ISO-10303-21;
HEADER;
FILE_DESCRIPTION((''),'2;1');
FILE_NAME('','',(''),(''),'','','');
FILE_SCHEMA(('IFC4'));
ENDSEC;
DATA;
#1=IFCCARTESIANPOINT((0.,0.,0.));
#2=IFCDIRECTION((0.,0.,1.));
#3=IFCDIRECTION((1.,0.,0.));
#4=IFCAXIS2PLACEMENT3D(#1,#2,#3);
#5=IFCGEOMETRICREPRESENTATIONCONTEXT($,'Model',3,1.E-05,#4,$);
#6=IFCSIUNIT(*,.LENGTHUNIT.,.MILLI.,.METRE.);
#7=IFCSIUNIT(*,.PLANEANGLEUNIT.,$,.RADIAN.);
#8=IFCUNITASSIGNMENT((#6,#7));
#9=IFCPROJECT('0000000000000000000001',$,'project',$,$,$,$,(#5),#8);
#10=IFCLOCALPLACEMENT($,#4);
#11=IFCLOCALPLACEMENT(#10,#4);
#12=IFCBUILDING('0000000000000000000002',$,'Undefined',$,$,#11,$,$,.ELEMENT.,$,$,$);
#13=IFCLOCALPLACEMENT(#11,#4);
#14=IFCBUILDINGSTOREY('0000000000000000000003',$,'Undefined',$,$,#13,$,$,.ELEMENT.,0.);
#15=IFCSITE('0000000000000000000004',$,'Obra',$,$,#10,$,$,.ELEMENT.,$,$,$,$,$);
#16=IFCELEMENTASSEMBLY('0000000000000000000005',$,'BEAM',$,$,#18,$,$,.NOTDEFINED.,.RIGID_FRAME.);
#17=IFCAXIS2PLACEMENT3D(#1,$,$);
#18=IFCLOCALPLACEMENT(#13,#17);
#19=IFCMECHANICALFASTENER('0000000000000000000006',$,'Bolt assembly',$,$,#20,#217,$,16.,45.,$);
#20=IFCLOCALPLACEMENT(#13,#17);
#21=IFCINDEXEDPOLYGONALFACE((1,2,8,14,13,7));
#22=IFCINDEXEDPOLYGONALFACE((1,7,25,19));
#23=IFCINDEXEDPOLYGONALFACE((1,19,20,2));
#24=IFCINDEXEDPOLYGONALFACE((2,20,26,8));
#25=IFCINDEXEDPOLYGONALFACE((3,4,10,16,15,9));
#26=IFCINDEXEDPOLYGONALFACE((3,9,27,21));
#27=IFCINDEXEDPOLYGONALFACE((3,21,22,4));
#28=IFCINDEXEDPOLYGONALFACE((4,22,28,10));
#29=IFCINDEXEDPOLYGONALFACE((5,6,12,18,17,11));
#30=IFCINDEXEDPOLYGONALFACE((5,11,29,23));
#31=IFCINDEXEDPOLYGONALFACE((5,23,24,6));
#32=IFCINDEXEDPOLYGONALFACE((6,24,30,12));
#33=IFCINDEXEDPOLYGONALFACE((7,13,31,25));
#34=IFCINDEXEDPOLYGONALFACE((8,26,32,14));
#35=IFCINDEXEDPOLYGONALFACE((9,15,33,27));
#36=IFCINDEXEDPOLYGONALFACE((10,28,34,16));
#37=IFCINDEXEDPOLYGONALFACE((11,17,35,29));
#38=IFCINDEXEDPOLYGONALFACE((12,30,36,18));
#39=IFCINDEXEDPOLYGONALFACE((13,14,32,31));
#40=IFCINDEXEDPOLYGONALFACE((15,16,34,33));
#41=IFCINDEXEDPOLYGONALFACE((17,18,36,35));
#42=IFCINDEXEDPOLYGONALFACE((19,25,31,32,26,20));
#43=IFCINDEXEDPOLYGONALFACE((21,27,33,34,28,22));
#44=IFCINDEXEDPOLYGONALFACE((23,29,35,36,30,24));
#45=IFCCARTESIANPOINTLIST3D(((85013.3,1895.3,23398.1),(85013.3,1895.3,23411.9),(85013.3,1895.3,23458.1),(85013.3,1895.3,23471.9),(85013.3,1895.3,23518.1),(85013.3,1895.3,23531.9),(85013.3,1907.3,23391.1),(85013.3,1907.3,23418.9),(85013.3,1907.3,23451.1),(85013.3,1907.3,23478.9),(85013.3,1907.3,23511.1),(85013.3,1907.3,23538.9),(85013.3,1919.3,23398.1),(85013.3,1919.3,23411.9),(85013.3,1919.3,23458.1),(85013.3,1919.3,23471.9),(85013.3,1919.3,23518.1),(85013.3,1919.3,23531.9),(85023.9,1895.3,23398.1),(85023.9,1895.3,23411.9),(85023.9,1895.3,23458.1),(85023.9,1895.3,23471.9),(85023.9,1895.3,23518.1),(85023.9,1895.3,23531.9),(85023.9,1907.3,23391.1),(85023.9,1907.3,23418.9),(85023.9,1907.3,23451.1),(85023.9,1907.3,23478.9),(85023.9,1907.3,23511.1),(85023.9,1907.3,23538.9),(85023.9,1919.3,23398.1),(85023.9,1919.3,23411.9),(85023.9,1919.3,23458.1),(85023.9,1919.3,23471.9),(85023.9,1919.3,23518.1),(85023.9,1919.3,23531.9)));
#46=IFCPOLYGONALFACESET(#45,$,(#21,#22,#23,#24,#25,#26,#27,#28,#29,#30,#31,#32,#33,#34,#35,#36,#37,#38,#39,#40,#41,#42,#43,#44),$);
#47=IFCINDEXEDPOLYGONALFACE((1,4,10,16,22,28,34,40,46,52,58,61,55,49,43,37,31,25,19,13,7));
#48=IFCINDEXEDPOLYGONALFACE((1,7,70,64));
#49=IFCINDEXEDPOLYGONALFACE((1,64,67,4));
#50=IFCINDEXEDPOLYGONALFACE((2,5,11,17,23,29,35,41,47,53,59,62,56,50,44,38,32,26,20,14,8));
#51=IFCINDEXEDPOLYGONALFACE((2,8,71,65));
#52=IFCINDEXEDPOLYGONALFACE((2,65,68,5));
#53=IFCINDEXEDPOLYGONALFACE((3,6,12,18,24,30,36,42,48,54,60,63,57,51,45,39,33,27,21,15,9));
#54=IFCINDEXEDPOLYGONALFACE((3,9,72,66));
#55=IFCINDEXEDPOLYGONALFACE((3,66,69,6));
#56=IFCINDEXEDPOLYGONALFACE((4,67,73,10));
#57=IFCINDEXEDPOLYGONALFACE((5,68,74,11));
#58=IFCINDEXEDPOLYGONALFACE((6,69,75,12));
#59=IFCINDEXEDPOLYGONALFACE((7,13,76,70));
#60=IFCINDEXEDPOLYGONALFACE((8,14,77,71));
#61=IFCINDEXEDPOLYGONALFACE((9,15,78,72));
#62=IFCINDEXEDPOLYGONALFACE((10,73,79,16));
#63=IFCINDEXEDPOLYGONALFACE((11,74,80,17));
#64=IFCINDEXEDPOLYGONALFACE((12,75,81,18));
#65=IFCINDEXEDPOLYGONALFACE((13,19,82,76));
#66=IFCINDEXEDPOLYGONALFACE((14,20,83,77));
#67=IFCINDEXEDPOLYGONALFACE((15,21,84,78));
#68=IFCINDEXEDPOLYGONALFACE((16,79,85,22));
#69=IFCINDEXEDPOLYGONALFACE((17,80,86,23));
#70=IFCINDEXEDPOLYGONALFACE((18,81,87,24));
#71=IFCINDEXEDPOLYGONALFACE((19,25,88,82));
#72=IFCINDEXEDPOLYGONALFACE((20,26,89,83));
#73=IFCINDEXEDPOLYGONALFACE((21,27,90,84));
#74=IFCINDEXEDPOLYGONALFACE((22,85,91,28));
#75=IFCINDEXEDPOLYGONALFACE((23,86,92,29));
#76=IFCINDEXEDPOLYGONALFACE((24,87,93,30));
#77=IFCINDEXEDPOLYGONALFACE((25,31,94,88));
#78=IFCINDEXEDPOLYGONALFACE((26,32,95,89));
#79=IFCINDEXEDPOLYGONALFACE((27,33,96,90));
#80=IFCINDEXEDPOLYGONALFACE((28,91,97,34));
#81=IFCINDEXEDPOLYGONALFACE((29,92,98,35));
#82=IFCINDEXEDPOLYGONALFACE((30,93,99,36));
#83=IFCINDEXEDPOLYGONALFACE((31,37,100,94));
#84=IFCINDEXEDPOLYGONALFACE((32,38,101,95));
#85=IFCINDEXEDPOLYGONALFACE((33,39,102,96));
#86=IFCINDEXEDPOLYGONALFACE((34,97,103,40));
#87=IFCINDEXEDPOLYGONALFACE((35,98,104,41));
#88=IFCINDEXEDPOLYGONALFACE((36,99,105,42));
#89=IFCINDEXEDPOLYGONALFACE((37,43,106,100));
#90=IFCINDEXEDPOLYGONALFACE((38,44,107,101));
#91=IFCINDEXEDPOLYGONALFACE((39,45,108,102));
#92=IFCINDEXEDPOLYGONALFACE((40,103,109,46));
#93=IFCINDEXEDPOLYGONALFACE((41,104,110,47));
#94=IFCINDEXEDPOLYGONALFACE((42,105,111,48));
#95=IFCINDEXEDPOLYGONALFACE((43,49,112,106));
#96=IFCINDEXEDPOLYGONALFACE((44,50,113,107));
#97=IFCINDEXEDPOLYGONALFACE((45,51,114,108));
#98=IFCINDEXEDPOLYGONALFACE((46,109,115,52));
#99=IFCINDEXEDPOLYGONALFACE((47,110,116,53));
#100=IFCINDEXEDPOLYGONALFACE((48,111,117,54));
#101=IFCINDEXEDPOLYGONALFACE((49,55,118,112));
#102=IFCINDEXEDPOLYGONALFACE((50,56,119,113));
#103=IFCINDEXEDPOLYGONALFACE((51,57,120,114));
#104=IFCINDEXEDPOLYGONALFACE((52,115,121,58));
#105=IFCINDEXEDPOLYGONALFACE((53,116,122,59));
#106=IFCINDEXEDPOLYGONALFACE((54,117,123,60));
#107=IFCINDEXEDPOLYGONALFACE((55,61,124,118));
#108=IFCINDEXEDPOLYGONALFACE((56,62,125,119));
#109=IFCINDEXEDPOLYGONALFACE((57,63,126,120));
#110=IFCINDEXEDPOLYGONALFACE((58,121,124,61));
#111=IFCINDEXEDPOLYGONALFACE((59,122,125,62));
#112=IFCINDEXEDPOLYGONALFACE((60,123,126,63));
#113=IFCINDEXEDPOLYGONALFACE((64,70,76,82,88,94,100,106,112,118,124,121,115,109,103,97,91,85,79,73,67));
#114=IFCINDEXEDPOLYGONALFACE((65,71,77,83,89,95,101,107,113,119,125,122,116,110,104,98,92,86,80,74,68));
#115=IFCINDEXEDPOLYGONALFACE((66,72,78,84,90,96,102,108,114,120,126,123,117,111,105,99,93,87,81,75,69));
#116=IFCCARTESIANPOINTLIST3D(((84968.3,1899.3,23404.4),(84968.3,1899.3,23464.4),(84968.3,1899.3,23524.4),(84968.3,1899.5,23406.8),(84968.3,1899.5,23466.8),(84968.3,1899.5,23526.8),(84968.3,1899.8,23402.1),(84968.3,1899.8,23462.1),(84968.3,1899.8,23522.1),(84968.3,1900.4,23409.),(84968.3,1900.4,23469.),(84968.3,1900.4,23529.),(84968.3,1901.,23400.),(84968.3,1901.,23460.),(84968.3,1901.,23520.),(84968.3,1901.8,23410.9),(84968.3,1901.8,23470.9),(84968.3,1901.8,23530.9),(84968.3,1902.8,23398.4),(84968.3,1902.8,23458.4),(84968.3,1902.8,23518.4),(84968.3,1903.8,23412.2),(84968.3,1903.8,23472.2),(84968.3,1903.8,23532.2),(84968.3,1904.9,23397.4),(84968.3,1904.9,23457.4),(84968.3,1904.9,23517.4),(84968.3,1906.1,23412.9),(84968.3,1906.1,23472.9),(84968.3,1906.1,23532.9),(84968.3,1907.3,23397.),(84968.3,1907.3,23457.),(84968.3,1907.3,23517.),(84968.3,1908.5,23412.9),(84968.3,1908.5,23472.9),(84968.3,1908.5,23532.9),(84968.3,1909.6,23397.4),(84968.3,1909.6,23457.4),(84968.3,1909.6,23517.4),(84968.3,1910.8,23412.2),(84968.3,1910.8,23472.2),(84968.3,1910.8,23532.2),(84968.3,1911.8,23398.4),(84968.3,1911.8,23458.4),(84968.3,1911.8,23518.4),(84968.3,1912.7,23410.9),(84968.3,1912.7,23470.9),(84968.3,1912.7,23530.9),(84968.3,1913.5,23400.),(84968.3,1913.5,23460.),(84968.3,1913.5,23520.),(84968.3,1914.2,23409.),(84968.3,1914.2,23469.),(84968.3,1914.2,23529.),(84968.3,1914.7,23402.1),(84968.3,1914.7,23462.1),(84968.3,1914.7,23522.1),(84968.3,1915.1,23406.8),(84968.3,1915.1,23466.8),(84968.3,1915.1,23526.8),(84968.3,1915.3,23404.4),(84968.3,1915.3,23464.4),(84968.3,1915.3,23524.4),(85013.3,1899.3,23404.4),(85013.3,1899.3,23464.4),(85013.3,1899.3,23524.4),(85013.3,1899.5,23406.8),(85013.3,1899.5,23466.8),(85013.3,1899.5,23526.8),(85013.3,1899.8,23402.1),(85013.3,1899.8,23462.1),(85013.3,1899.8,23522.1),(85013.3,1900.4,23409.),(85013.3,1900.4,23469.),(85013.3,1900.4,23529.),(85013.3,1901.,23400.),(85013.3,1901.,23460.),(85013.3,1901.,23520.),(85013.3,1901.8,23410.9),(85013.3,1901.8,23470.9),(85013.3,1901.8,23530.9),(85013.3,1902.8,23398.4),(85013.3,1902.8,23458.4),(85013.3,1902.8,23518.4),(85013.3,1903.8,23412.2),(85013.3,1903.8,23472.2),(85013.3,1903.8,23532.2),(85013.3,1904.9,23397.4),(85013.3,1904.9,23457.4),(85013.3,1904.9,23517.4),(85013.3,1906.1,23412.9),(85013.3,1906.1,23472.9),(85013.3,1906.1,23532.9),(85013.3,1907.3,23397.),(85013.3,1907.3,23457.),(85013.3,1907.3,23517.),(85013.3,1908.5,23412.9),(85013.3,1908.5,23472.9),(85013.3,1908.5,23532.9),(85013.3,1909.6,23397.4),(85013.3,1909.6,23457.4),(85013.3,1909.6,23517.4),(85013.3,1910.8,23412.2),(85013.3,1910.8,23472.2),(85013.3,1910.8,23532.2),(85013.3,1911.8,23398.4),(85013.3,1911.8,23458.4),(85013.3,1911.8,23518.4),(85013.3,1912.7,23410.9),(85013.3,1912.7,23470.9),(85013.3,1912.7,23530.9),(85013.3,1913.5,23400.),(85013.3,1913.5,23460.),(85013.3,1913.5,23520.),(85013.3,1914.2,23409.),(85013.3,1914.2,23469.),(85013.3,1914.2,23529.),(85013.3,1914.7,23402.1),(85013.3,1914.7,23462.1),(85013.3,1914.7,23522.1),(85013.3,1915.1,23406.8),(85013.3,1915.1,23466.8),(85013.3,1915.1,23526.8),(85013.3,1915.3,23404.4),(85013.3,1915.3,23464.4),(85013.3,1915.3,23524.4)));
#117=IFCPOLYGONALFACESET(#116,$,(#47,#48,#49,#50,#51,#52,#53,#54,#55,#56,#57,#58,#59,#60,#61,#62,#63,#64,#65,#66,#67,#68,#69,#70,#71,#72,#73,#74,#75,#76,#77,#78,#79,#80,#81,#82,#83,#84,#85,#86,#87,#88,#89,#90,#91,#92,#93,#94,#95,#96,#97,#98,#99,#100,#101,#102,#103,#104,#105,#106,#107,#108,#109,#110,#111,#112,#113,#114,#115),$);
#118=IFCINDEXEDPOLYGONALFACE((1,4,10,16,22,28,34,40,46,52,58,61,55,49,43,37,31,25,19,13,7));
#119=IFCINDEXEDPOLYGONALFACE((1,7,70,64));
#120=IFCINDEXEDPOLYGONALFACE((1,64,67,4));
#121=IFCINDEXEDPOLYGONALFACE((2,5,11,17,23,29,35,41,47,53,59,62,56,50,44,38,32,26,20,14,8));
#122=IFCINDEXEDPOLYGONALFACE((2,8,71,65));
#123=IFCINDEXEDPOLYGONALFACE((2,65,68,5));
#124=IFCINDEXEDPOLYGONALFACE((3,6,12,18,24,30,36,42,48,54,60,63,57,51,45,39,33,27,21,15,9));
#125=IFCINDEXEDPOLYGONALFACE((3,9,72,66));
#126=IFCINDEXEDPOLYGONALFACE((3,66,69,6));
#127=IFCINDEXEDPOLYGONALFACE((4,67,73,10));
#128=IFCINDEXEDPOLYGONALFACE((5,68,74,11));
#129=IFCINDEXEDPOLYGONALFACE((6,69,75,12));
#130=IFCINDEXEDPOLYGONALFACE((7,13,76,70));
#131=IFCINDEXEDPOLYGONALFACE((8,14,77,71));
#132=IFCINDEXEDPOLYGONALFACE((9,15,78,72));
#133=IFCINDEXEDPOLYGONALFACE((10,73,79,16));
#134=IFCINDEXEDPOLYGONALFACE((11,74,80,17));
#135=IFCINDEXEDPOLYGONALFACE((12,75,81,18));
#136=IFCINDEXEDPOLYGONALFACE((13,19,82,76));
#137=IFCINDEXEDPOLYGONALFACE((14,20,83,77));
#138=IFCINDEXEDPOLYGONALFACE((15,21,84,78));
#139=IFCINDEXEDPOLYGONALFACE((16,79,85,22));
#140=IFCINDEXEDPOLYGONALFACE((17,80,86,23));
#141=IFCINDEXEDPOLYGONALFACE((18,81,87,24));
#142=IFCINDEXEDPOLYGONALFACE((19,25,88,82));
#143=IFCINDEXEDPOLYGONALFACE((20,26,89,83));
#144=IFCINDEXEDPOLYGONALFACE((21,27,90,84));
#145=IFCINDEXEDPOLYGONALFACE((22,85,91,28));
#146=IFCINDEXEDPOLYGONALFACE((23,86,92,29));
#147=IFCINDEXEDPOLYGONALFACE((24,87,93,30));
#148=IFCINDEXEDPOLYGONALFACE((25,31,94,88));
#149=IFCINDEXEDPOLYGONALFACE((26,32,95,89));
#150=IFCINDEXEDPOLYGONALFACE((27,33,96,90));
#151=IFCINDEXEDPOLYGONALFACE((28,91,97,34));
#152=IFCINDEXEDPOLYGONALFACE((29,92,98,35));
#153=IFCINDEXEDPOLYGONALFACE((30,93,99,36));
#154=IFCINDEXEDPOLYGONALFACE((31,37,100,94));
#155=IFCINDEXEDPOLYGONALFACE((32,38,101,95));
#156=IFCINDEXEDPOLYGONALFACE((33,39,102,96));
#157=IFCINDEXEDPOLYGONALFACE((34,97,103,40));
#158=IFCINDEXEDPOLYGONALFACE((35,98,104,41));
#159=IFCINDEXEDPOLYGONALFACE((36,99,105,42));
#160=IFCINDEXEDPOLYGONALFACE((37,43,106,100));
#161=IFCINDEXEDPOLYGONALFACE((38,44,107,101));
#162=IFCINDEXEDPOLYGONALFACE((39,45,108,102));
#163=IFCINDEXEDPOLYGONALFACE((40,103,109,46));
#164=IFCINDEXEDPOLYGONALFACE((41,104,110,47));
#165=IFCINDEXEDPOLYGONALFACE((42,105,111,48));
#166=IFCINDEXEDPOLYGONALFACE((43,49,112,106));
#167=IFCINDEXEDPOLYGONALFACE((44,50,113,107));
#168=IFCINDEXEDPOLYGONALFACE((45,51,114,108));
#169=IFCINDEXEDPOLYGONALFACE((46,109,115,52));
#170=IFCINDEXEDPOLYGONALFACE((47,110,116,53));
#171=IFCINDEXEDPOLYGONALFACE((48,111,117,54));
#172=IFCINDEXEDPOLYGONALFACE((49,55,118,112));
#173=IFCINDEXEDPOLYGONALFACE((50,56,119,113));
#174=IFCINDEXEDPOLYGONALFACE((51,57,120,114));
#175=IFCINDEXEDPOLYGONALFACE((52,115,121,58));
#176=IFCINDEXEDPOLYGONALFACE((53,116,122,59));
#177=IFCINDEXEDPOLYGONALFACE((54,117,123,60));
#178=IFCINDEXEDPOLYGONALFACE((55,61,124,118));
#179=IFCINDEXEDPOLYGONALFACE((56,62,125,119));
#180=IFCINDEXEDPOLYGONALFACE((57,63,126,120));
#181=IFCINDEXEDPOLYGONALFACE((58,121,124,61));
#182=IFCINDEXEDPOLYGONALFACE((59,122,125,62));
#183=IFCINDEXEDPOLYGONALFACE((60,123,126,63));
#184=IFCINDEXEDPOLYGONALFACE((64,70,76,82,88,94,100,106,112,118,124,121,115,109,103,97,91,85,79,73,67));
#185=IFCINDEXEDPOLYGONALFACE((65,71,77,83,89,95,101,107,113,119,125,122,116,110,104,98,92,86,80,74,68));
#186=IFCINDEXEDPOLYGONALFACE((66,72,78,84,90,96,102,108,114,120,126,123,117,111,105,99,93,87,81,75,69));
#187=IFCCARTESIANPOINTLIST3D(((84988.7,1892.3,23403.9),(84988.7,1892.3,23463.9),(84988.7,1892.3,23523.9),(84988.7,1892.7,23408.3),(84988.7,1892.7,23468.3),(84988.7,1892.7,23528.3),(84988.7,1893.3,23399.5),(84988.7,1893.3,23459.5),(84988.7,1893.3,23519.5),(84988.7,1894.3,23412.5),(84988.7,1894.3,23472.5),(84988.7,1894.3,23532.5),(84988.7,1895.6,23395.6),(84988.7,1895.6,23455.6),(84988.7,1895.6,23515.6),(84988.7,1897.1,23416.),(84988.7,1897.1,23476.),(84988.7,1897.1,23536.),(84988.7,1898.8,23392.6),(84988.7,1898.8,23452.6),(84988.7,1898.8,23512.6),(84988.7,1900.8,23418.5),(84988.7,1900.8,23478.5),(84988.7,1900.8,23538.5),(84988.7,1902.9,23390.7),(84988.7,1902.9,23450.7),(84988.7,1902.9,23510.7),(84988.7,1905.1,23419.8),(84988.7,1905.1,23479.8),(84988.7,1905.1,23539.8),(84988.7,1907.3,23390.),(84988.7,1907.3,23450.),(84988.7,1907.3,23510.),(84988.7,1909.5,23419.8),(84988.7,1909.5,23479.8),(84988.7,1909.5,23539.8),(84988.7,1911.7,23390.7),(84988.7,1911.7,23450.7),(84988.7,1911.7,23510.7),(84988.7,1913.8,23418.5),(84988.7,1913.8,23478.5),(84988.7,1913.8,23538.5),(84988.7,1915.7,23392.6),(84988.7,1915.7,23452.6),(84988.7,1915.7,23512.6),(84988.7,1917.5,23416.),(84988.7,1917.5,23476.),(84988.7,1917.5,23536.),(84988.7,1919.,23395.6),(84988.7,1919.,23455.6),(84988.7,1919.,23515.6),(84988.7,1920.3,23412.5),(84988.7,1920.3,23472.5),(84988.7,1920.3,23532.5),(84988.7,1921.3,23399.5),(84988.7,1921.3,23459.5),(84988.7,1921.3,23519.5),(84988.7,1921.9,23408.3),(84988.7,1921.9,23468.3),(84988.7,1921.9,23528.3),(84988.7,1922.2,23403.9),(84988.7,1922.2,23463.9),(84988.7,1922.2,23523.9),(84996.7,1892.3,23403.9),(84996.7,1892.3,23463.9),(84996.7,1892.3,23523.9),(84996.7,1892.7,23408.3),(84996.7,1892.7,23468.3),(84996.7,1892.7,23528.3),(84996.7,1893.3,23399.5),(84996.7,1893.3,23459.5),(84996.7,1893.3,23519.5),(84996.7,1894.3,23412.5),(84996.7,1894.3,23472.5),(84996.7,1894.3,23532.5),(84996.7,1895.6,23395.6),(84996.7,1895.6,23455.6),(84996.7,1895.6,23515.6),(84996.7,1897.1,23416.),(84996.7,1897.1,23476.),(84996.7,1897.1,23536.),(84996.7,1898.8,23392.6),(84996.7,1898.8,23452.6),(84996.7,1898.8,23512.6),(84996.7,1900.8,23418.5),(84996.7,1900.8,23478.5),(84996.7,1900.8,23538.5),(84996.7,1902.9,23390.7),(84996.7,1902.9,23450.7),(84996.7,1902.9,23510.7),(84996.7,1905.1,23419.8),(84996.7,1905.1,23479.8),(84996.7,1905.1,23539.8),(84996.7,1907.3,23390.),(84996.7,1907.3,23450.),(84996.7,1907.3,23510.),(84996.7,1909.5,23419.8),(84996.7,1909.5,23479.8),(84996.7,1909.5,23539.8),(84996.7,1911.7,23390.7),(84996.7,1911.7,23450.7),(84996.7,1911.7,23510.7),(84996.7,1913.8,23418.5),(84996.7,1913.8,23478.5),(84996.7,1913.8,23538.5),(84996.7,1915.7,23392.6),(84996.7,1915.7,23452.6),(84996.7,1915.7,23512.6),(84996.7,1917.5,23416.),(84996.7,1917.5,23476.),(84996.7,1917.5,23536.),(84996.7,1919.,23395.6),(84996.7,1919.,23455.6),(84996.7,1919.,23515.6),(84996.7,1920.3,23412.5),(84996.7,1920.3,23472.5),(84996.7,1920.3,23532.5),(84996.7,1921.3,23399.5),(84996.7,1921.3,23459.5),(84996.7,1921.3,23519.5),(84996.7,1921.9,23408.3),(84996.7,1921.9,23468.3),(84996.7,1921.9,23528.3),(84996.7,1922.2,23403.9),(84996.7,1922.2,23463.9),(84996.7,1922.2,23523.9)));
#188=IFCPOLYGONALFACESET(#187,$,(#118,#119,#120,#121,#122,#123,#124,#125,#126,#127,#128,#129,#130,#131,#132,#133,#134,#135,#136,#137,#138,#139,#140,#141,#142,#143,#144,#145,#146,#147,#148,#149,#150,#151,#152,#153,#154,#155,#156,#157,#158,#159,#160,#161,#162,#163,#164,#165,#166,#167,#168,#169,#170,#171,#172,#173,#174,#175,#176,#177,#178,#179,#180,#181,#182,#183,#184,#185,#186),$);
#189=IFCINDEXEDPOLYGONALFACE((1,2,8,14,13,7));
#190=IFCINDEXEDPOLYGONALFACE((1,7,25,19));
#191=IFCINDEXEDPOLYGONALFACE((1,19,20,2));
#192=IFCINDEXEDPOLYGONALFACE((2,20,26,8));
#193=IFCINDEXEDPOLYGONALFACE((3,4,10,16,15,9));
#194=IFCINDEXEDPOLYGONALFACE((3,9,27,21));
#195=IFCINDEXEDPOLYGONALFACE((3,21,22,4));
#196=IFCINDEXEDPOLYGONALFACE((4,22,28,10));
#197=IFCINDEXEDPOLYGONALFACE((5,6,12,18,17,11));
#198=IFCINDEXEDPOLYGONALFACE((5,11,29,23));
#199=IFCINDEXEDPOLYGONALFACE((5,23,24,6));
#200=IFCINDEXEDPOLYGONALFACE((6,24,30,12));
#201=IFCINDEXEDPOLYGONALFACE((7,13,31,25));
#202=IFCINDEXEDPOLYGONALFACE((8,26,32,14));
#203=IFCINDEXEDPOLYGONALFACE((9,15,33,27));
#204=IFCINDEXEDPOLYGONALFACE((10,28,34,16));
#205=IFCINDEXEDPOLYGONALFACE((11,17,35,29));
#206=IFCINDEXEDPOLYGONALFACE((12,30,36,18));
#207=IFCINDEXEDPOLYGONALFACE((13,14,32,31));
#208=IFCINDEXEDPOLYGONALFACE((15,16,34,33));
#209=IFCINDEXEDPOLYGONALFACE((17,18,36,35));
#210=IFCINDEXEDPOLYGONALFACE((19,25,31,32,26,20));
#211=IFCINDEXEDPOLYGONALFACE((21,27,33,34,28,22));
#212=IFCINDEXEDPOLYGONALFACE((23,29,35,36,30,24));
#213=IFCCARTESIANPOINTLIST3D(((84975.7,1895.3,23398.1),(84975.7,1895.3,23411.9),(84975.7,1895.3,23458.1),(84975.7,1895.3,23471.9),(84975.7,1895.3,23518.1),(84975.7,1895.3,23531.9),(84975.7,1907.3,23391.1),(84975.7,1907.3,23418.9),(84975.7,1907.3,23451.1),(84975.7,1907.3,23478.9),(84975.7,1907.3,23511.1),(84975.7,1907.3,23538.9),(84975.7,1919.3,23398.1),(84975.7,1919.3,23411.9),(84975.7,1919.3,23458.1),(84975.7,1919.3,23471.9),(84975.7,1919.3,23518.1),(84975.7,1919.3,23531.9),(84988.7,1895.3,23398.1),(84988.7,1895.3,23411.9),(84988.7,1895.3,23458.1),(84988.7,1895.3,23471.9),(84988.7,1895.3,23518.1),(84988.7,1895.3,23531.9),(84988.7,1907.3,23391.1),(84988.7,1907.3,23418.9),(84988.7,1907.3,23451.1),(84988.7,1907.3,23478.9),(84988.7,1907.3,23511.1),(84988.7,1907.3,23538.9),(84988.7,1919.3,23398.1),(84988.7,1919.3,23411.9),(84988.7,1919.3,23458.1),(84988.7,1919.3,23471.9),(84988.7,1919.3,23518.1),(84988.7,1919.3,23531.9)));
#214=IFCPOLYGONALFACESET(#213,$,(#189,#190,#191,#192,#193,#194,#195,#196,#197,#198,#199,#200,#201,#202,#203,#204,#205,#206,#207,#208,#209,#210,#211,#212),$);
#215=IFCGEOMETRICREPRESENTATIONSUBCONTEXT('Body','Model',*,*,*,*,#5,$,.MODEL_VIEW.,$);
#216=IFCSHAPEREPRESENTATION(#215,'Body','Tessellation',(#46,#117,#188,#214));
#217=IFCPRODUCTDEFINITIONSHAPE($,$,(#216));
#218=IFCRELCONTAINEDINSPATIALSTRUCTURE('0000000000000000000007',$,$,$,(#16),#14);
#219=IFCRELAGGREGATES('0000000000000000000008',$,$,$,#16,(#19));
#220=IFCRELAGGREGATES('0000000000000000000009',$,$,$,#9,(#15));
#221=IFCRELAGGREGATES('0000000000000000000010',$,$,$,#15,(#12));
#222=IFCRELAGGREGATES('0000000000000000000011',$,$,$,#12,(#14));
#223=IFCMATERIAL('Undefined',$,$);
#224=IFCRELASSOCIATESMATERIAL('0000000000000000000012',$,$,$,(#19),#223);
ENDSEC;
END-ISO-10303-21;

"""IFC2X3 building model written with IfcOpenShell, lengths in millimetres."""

from ifc_helpers import new_model, si_unit, frame, origin_with_axes, origin_2d_with_axis, place, context, subcontext, project, spatial, polyline, circle, outline, extrude, source, transform, mapped, material, element, aggregate, save


model = new_model("IFC2X3")

# Units and contexts
model_context = context("Model", 3, precision=1e-05, world=origin_with_axes())
body_context = subcontext(model_context, "Body", "Model", "MODEL_VIEW")
ifc_project = project(units=[si_unit("LENGTHUNIT", "METRE", prefix="MILLI"), si_unit("PLANEANGLEUNIT", "RADIAN")], contexts=[model_context])

# Site, building, storey
site_placement = place(None, origin_with_axes())
site = spatial("IfcSite", under=ifc_project, at=site_placement, Name="Obra", CompositionType="ELEMENT")
building_placement = place(site_placement, origin_with_axes())
building = spatial("IfcBuilding", under=site, at=building_placement, Name="Undefined", CompositionType="ELEMENT")
storey_placement = place(building_placement, origin_with_axes())
storey = spatial("IfcBuildingStorey", under=building, at=storey_placement, Name="Undefined", CompositionType="ELEMENT", Elevation=0.0)

# Shared definitions
ifc_material_1 = material(Name="Undefined")

# Element assembly, mechanical fastener
assembly_1_placement = place(storey_placement, origin_with_axes())
assembly_1 = element("IfcElementAssembly", 1, at=assembly_1_placement, inside=storey, Name="BEAM", AssemblyPlace="NOTDEFINED", PredefinedType="RIGID_FRAME")
shared_shape_1 = source(origin_with_axes(), body_context, "Body", "SweptSolid", [
    extrude(outline(polyline([(13.9, 0.0), (6.9, 12.0), (-6.9, 12.0), (-13.9, 0.0), (-6.9, -12.0), (6.9, -12.0), (13.9, 0.0)])), frame((0.0, -23.9, 0.0), z_axis=(0.0, 1.0, 0.0), x_axis=(1.0, 0.0, 0.0)), (0.0, 0.0, 1.0), 10.6),
    extrude(circle(Radius=8.0, at=origin_2d_with_axis()), frame((0.0, -13.3, 0.0), z_axis=(0.0, 1.0, 0.0), x_axis=(1.0, 0.0, 0.0)), (0.0, 0.0, 1.0), 45.0),
    extrude(circle(Radius=15.0, at=origin_2d_with_axis()), frame((0.0, 3.3, 0.0), z_axis=(0.0, 1.0, 0.0), x_axis=(1.0, 0.0, 0.0)), (0.0, 0.0, 1.0), 8.0),
    extrude(outline(polyline([(13.9, 0.0), (6.9, 12.0), (-6.9, 12.0), (-13.9, 0.0), (-6.9, -12.0), (6.9, -12.0), (13.9, 0.0)])), frame((0.0, 11.3, 0.0), z_axis=(0.0, 1.0, 0.0), x_axis=(1.0, 0.0, 0.0)), (0.0, 0.0, 1.0), 13.0),
])
mechanical_fastener_1_placement = place(assembly_1_placement, frame((85000.0, 1867.3, 23600.0), z_axis=(0.0, 1.0, 0.0), x_axis=(0.0, 0.0, -1.0)))
mechanical_fastener_1 = element("IfcMechanicalFastener", 2, at=mechanical_fastener_1_placement, material=ifc_material_1, Name="Bolt assembly", NominalDiameter=16.0, NominalLength=45.0, context=body_context, shape_type="MappedRepresentation", body=[
    mapped(shared_shape_1, transform((75.0, 0.0, 40.0))),
    mapped(shared_shape_1, transform((135.0, 0.0, 40.0))),
    mapped(shared_shape_1, transform((195.0, 0.0, 40.0))),
])
aggregate(assembly_1, [mechanical_fastener_1])

save(model, "model.ifc")
